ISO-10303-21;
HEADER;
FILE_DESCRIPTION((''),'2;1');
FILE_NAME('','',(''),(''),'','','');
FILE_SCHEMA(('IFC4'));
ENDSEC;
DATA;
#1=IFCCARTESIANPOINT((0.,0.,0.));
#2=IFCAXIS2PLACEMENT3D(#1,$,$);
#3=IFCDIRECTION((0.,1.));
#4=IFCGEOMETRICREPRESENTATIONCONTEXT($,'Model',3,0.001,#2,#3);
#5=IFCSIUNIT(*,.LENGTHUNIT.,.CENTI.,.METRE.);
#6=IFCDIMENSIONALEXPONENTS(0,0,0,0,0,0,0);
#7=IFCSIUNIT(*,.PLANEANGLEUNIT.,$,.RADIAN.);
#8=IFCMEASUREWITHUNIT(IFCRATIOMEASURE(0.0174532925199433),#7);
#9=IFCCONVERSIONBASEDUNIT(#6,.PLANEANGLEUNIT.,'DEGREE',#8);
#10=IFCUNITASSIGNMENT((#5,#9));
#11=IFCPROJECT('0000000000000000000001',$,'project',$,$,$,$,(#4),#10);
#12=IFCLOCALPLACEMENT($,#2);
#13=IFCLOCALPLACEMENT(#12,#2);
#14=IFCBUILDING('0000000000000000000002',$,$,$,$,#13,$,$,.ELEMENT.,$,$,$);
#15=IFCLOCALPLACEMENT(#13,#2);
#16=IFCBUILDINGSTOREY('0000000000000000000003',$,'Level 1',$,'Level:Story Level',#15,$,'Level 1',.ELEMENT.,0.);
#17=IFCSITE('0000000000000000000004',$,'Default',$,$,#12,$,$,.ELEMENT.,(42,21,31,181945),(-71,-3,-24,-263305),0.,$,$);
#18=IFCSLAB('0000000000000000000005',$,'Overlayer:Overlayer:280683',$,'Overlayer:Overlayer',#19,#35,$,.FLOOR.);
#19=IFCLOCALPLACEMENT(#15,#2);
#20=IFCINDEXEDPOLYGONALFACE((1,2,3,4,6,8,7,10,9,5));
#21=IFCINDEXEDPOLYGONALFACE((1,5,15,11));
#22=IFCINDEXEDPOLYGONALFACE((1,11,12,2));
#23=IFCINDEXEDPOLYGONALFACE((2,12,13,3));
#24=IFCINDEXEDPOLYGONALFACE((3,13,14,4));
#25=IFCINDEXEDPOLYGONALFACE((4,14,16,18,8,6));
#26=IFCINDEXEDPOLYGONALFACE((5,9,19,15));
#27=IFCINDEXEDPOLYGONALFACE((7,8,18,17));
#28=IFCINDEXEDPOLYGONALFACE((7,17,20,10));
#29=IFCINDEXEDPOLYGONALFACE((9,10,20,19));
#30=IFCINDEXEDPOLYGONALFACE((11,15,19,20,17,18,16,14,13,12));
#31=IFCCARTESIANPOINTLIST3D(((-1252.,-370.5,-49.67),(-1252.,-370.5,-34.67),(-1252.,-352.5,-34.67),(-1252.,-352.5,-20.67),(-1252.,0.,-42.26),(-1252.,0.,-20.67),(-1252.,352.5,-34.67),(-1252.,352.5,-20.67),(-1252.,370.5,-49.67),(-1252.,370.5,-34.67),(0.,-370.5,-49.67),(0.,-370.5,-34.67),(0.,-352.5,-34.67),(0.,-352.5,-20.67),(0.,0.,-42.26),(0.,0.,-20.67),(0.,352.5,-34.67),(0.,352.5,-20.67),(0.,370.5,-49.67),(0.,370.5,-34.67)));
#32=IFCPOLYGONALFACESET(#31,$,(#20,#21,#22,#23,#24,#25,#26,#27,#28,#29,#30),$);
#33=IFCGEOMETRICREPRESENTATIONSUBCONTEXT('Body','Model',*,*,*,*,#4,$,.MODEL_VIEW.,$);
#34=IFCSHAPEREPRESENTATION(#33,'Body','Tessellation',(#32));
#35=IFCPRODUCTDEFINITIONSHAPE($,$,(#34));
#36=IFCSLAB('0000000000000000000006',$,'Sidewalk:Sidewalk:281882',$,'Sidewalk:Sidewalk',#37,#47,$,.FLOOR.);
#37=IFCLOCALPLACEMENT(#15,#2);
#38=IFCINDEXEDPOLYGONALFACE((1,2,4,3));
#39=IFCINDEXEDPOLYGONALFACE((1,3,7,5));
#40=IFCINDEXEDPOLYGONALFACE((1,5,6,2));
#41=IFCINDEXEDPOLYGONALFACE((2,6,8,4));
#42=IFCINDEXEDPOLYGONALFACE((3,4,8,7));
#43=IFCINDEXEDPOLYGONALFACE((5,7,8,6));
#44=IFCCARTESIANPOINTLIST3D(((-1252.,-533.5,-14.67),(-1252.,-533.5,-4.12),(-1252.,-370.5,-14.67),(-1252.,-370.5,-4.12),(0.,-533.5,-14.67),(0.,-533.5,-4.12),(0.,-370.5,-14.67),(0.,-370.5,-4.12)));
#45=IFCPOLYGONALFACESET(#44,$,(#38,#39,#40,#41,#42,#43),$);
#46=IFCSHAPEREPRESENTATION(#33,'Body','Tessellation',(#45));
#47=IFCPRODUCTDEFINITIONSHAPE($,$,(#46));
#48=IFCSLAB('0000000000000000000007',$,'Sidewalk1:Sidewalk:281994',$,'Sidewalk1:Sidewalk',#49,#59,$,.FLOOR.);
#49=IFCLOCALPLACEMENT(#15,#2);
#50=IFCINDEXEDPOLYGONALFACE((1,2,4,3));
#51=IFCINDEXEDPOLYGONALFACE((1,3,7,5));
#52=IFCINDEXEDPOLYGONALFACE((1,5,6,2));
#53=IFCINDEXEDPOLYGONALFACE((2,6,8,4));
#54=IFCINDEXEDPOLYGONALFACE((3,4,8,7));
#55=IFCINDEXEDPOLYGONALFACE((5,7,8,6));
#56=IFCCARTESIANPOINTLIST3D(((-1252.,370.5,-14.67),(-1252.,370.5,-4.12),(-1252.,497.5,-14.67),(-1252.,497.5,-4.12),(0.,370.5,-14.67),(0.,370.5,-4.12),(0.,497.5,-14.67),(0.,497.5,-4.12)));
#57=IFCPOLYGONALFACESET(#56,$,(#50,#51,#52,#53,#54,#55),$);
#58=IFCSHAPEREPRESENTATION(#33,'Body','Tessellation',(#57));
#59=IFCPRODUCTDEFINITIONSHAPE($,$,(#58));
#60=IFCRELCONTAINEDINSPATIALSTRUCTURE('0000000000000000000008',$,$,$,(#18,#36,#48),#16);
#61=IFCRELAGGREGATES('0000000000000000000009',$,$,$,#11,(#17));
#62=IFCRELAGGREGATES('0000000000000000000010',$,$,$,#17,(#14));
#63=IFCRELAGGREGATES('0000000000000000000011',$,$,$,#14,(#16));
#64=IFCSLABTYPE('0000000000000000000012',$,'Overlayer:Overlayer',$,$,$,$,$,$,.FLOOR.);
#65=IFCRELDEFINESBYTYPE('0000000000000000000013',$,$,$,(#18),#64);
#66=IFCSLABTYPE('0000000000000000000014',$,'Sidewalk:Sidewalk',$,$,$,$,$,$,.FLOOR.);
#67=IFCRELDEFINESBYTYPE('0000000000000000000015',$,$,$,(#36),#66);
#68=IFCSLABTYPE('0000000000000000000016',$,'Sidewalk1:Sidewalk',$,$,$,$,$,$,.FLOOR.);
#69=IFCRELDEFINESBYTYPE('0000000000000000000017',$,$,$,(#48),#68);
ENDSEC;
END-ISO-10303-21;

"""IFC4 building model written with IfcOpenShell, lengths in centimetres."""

from ifc_helpers import new_model, entity, si_unit, converted_unit, direction, frame, frame_2d, origin, origin_2d_with_axis, place, context, subcontext, project, spatial, polyline, rectangle, outline, extrude, type_object, element, save


model = new_model("IFC4")

# Units and contexts
model_context = context("Model", 3, precision=0.001, world=origin(), true_north=direction((0.0, 1.0)))
body_context = subcontext(model_context, "Body", "Model", "MODEL_VIEW")
ifc_project = project(units=[si_unit("LENGTHUNIT", "METRE", prefix="CENTI"), converted_unit("PLANEANGLEUNIT", "DEGREE", entity("IfcRatioMeasure", 0.0174532925199433), si_unit("PLANEANGLEUNIT", "RADIAN"), dimensions=[0, 0, 0, 0, 0, 0, 0])], contexts=[model_context])

# Site, building, storey
site_placement = place(None, origin())
site = spatial("IfcSite", under=ifc_project, at=site_placement, Name="Default", CompositionType="ELEMENT", RefLatitude=(42, 21, 31, 181945), RefLongitude=(-71, -3, -24, -263305), RefElevation=0.0)
building_placement = place(site_placement, origin())
building = spatial("IfcBuilding", under=site, at=building_placement, CompositionType="ELEMENT")
storey_placement = place(building_placement, origin())
storey = spatial("IfcBuildingStorey", under=building, at=storey_placement, Name="Level 1", ObjectType="Level:Story Level", LongName="Level 1", CompositionType="ELEMENT", Elevation=0.0)

# Slabs
slab_type_1 = type_object("IfcSlabType", Name="Overlayer:Overlayer", PredefinedType="FLOOR")
slab_1_placement = place(storey_placement, origin())
element("IfcSlab", 1, at=slab_1_placement, inside=storey, type_object=slab_type_1, Name="Overlayer:Overlayer:280683", ObjectType="Overlayer:Overlayer", PredefinedType="FLOOR", context=body_context, shape_type="SweptSolid", body=[
    extrude(outline(polyline([(352.5, 0.44), (370.5, 0.44), (370.5, 15.44), (0.0, 8.03), (-370.5, 15.44), (-370.5, 0.44), (-352.5, 0.44), (-352.5, -13.56), (0.0, -13.56), (352.5, -13.56), (352.5, 0.44)])), frame((-1252.0, 0.0, -34.23), z_axis=(1.0, 0.0, 0.0), x_axis=(0.0, -1.0, 0.0)), (0.0, 0.0, 1.0), 1252.0),
])
slab_type_2 = type_object("IfcSlabType", Name="Sidewalk:Sidewalk", PredefinedType="FLOOR")
slab_2_placement = place(storey_placement, origin())
element("IfcSlab", 2, at=slab_2_placement, inside=storey, type_object=slab_type_2, Name="Sidewalk:Sidewalk:281882", ObjectType="Sidewalk:Sidewalk", PredefinedType="FLOOR", context=body_context, shape_type="SweptSolid", body=[
    extrude(rectangle(XDim=1252.0, YDim=163.0, at=frame_2d((0.0, 0.0), x_axis=(1.0, 0.0))), frame((-626.0, -452.0, -14.67)), (0.0, 0.0, 1.0), 10.55),
])
slab_type_3 = type_object("IfcSlabType", Name="Sidewalk1:Sidewalk", PredefinedType="FLOOR")
slab_3_placement = place(storey_placement, origin())
element("IfcSlab", 3, at=slab_3_placement, inside=storey, type_object=slab_type_3, Name="Sidewalk1:Sidewalk:281994", ObjectType="Sidewalk1:Sidewalk", PredefinedType="FLOOR", context=body_context, shape_type="SweptSolid", body=[
    extrude(rectangle(XDim=1252.0, YDim=127.0, at=origin_2d_with_axis()), frame((-626.0, 434.0, -14.67)), (0.0, 0.0, 1.0), 10.55),
])

save(model, "model.ifc")
